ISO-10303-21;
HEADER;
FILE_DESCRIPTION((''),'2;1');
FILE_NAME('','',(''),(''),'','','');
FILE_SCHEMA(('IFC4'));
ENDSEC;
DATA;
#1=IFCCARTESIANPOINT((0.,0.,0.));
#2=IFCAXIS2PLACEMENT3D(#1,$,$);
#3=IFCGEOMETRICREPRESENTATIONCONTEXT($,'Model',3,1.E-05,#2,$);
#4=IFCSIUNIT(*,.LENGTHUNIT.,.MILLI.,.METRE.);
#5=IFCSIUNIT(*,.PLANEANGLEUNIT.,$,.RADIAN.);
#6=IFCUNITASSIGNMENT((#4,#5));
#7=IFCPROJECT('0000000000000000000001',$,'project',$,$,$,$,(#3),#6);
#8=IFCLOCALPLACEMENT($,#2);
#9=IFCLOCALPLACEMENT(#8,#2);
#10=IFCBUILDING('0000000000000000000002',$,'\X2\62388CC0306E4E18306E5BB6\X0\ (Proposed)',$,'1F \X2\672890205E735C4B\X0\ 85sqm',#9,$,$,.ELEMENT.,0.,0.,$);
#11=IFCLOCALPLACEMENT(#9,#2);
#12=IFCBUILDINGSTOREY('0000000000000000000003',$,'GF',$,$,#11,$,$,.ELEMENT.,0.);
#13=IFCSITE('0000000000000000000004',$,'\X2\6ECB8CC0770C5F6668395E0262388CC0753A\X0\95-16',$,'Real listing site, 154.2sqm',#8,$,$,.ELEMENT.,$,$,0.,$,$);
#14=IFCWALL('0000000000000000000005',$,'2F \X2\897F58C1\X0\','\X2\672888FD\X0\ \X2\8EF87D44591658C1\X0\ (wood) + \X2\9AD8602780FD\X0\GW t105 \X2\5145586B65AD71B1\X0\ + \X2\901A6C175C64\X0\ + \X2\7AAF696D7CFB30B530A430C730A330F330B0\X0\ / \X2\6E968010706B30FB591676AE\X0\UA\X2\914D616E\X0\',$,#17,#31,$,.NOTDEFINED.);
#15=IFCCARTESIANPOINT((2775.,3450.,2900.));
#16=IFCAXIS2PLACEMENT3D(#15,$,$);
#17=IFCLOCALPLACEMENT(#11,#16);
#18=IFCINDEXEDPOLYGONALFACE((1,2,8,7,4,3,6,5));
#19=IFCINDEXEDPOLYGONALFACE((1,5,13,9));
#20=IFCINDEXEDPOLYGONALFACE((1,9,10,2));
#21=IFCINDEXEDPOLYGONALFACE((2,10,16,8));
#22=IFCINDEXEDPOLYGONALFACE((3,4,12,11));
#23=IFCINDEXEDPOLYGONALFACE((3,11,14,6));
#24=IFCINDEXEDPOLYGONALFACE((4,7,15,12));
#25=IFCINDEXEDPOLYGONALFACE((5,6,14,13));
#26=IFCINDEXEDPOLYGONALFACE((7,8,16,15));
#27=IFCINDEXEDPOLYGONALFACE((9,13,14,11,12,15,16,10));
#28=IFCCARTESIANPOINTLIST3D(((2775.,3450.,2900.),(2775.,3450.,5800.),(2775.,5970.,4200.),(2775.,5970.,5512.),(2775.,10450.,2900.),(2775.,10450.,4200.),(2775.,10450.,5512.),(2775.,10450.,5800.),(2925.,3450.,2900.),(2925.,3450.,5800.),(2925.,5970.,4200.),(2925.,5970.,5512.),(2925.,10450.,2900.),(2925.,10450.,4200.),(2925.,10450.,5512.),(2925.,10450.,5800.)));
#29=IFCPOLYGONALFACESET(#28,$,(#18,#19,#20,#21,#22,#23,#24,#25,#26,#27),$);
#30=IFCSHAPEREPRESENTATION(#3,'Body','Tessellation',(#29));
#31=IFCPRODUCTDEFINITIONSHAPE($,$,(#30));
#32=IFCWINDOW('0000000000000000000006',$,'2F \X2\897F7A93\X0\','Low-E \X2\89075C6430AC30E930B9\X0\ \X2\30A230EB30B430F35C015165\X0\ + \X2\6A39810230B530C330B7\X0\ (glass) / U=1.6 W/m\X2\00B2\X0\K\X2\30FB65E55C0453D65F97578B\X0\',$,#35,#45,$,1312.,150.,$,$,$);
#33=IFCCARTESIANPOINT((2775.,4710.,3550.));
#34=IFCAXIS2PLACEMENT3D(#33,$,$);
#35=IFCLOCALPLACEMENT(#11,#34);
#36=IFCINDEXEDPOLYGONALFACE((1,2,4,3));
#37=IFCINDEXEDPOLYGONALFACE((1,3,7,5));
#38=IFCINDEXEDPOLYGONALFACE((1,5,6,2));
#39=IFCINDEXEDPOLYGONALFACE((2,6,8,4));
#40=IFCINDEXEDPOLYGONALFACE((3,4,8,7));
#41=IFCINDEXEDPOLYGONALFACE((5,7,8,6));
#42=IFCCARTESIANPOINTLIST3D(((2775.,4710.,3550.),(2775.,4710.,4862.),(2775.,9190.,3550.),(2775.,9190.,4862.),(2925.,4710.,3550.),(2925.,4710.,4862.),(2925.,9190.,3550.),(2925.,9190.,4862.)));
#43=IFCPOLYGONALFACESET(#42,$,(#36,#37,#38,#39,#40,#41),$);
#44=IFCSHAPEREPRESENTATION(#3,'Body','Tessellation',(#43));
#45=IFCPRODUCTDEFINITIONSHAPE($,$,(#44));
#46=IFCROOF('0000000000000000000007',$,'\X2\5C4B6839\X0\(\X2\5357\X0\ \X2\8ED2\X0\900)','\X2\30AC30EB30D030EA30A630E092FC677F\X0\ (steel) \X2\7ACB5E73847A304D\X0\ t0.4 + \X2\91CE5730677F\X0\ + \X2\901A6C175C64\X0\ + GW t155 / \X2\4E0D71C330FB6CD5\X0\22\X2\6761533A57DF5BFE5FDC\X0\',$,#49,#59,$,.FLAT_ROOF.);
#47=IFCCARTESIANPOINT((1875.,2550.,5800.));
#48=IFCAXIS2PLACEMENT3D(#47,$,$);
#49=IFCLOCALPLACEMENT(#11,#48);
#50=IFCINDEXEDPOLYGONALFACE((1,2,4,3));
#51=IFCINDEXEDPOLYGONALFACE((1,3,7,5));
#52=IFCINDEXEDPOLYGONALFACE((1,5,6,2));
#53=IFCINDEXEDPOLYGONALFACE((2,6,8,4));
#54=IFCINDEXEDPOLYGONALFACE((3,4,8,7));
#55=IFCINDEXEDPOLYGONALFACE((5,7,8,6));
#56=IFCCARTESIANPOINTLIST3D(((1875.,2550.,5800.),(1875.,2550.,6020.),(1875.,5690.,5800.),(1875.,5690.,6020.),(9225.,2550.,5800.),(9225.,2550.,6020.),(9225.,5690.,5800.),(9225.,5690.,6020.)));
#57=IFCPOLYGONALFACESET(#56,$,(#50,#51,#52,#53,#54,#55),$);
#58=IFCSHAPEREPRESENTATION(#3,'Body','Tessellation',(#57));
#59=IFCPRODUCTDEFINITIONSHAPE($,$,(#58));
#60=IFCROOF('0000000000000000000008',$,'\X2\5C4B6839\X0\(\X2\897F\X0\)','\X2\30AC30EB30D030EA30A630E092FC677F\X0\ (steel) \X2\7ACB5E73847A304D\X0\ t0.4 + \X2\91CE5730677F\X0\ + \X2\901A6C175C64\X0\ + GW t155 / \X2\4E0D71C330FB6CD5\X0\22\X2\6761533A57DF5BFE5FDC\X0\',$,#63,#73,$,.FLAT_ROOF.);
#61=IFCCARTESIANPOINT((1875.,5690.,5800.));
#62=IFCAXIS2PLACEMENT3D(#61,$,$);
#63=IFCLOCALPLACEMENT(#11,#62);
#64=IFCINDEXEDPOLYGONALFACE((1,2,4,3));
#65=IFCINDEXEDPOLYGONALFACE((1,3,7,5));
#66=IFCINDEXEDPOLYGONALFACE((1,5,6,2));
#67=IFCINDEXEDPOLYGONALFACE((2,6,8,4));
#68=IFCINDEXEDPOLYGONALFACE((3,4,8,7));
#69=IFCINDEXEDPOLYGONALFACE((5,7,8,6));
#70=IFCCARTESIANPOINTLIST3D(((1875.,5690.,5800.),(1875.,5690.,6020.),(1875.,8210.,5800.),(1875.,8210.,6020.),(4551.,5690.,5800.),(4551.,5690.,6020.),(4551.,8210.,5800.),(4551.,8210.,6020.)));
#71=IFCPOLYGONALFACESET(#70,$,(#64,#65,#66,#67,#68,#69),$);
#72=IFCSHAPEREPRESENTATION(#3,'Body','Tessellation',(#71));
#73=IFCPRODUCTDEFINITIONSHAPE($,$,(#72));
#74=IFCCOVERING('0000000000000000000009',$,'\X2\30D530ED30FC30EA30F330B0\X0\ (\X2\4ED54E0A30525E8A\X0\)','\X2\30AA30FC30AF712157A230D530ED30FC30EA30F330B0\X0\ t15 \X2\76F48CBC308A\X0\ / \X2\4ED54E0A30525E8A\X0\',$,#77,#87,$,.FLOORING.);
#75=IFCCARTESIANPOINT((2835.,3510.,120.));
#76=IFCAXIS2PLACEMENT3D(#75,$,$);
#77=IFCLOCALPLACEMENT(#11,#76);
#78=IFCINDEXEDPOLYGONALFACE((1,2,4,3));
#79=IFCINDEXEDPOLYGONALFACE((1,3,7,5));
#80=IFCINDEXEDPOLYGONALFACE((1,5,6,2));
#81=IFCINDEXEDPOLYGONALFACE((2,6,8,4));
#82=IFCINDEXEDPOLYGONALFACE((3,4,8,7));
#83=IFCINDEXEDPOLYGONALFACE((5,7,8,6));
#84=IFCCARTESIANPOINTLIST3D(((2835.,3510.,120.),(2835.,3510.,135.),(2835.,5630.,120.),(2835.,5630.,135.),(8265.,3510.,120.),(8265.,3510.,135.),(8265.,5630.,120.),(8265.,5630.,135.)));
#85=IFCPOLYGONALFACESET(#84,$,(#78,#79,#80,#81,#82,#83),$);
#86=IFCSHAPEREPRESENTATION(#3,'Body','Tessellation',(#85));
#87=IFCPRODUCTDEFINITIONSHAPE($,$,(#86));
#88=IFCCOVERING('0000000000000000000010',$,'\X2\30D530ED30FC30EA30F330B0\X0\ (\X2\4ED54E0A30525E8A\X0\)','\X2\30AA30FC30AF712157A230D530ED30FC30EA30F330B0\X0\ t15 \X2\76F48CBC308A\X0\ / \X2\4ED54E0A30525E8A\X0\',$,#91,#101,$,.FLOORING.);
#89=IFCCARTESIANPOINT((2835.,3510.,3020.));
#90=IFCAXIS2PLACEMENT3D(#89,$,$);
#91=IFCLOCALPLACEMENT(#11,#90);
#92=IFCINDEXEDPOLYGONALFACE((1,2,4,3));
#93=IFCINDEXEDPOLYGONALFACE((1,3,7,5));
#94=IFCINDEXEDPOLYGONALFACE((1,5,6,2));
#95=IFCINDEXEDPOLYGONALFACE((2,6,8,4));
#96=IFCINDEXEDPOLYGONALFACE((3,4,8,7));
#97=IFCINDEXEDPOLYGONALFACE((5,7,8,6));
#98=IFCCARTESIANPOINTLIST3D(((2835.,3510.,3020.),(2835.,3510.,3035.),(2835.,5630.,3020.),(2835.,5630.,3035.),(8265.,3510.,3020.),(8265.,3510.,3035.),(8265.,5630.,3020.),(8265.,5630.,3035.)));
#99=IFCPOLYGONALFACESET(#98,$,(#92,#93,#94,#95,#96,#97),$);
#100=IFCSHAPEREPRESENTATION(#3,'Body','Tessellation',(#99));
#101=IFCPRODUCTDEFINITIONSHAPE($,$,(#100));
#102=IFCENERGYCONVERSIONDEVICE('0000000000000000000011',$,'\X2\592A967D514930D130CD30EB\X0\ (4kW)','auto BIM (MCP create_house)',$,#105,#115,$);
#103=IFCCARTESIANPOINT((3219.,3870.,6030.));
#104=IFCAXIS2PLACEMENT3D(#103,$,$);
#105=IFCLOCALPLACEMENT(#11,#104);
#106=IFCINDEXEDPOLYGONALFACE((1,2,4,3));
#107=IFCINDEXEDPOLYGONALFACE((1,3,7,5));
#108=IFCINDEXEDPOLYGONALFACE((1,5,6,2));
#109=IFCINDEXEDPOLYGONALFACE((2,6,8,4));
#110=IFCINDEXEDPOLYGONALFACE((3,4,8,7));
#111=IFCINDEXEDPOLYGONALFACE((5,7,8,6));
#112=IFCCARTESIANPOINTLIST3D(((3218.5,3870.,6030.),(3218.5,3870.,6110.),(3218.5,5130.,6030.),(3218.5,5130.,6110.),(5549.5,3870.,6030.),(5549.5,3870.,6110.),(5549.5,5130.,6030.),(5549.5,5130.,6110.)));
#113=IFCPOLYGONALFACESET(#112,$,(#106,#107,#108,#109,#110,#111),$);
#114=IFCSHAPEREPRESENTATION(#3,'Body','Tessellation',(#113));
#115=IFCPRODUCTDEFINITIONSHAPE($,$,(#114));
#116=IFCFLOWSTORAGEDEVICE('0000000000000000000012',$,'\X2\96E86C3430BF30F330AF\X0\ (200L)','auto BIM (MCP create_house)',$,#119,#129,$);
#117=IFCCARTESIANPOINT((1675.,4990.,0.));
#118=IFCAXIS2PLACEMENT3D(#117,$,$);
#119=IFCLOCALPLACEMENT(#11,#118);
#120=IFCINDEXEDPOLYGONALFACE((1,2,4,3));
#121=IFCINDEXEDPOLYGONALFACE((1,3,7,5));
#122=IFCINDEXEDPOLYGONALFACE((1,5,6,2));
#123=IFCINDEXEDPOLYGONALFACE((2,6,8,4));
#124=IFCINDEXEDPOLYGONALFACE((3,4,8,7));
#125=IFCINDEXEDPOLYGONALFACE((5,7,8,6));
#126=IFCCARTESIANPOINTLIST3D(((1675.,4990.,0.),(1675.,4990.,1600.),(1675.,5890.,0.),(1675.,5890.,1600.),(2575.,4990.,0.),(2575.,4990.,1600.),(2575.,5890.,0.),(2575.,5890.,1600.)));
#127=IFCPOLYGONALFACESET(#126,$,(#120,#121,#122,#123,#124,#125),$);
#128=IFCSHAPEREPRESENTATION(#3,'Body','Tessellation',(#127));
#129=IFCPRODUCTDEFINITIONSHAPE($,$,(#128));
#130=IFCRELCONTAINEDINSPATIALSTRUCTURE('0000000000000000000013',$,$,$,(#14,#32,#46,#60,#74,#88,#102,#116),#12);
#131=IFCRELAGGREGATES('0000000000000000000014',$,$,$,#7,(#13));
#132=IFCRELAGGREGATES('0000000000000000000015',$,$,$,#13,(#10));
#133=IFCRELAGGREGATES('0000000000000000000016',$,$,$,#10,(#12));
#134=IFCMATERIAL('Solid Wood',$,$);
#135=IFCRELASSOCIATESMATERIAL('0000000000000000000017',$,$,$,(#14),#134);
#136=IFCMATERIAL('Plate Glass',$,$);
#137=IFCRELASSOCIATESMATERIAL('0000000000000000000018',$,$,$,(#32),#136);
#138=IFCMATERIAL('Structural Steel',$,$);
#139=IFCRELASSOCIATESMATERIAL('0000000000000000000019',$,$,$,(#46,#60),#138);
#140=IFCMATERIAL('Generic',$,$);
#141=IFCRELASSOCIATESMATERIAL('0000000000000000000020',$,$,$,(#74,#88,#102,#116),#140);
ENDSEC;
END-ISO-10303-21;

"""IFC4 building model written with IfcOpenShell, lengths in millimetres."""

from ifc_helpers import new_model, si_unit, frame, frame_2d, origin, place, context, project, spatial, rectangle, extrude, material, element, fill, save


model = new_model("IFC4")

# Units and contexts
model_context = context("Model", 3, precision=1e-05, world=origin())
ifc_project = project(units=[si_unit("LENGTHUNIT", "METRE", prefix="MILLI"), si_unit("PLANEANGLEUNIT", "RADIAN")], contexts=[model_context])

# Site, building, storey
site_placement = place(None, origin())
site = spatial("IfcSite", under=ifc_project, at=site_placement, Name="滋賀県彦根市戸賀町95-16", ObjectType="Real listing site, 154.2sqm", CompositionType="ELEMENT", RefElevation=0.0)
building_placement = place(site_placement, origin())
building = spatial("IfcBuilding", under=site, at=building_placement, Name="戸賀の丘の家 (Proposed)", ObjectType="1F 木造平屋 85sqm", CompositionType="ELEMENT", ElevationOfRefHeight=0.0, ElevationOfTerrain=0.0)
storey_placement = place(building_placement, origin())
storey = spatial("IfcBuildingStorey", under=building, at=storey_placement, Name="GF", CompositionType="ELEMENT", Elevation=0.0)

# Shared definitions
ifc_material_1 = material(Name="Solid Wood")
ifc_material_2 = material(Name="Generic")

# Shared definitions
ifc_material_3 = material(Name="Plate Glass")

# Wall, opening, window
wall_1_placement = place(storey_placement, frame((2775.0, 3450.0, 2900.0)))
wall_1 = element("IfcWall", 1, at=wall_1_placement, inside=storey, material=ifc_material_1, Name="2F 西壁", Description="木製 軸組外壁 (wood) + 高性能GW t105 充填断熱 + 通気層 + 窯業系サイディング / 準耐火・外皮UA配慮", PredefinedType="NOTDEFINED", context=model_context, shape_type="SweptSolid", body=[
    extrude(rectangle(XDim=150.0, YDim=7000.0, at=frame_2d((75.0, 3500.0))), frame((2775.0, 3450.0, 2900.0)), (0.0, 0.0, 1.0), 2900.0),
])
opening_1_placement = place(storey_placement, frame((2775.0, 4710.0, 3550.0)))
opening_1 = element("IfcOpeningElement", 2, at=opening_1_placement, cuts=wall_1, PredefinedType="NOTDEFINED", context=model_context, shape_type="SweptSolid", body=[
    extrude(rectangle(XDim=150.0, YDim=4480.0, at=frame_2d((75.0, 2240.0))), frame((2775.0, 4710.0, 3550.0)), (0.0, 0.0, 1.0), 1312.0),
])
window_1_placement = place(storey_placement, frame((2775.0, 4710.0, 3550.0)))
window_1 = element("IfcWindow", 3, at=window_1_placement, inside=storey, material=ifc_material_3, Name="2F 西窓", Description="Low-E 複層ガラス アルゴン封入 + 樹脂サッシ (glass) / U=1.6 W/m²K・日射取得型", OverallHeight=1312.0, OverallWidth=150.0, context=model_context, shape_type="SweptSolid", body=[
    extrude(rectangle(XDim=150.0, YDim=4480.0, at=frame_2d((75.0, 2240.0))), frame((2775.0, 4710.0, 3550.0)), (0.0, 0.0, 1.0), 1312.0),
])
fill(opening_1, window_1)

# Roofs
ifc_material_4 = material(Name="Structural Steel")
roof_1_placement = place(storey_placement, frame((1875.0, 2550.0, 5800.0)))
element("IfcRoof", 4, at=roof_1_placement, inside=storey, material=ifc_material_4, Name="屋根(南 軒900)", Description="ガルバリウム鋼板 (steel) 立平葺き t0.4 + 野地板 + 通気層 + GW t155 / 不燃・法22条区域対応", PredefinedType="FLAT_ROOF", context=model_context, shape_type="SweptSolid", body=[
    extrude(rectangle(XDim=7350.0, YDim=3140.0, at=frame_2d((3675.0, 1570.0))), frame((1875.0, 2550.0, 5800.0)), (0.0, 0.0, 1.0), 220.0),
])
roof_2_placement = place(storey_placement, frame((1875.0, 5690.0, 5800.0)))
element("IfcRoof", 5, at=roof_2_placement, inside=storey, material=ifc_material_4, Name="屋根(西)", Description="ガルバリウム鋼板 (steel) 立平葺き t0.4 + 野地板 + 通気層 + GW t155 / 不燃・法22条区域対応", PredefinedType="FLAT_ROOF", context=model_context, shape_type="SweptSolid", body=[
    extrude(rectangle(XDim=2676.0, YDim=2520.0, at=frame_2d((1338.0, 1260.0))), frame((1875.0, 5690.0, 5800.0)), (0.0, 0.0, 1.0), 220.0),
])

# Coverings
covering_1_placement = place(storey_placement, frame((2835.0, 3510.0, 120.0)))
element("IfcCovering", 6, at=covering_1_placement, inside=storey, material=ifc_material_2, Name="フローリング (仕上げ床)", Description="オーク無垢フローリング t15 直貼り / 仕上げ床", PredefinedType="FLOORING", context=model_context, shape_type="SweptSolid", body=[
    extrude(rectangle(XDim=5430.0, YDim=2120.0, at=frame_2d((2715.0, 1060.0))), frame((2835.0, 3510.0, 120.0)), (0.0, 0.0, 1.0), 15.0),
])
covering_2_placement = place(storey_placement, frame((2835.0, 3510.0, 3020.0)))
element("IfcCovering", 7, at=covering_2_placement, inside=storey, material=ifc_material_2, Name="フローリング (仕上げ床)", Description="オーク無垢フローリング t15 直貼り / 仕上げ床", PredefinedType="FLOORING", context=model_context, shape_type="SweptSolid", body=[
    extrude(rectangle(XDim=5430.0, YDim=2120.0, at=frame_2d((2715.0, 1060.0))), frame((2835.0, 3510.0, 3020.0)), (0.0, 0.0, 1.0), 15.0),
])

# Energy conversion device
energy_conversion_device_placement = place(storey_placement, frame((3219.0, 3870.0, 6030.0)))
element("IfcEnergyConversionDevice", 8, at=energy_conversion_device_placement, inside=storey, material=ifc_material_2, Name="太陽光パネル (4kW)", Description="auto BIM (MCP create_house)", context=model_context, shape_type="SweptSolid", body=[
    extrude(rectangle(XDim=2331.0, YDim=1260.0, at=frame_2d((1165.0, 630.0))), frame((3219.0, 3870.0, 6030.0)), (0.0, 0.0, 1.0), 80.0),
])

# Flow storage device
flow_storage_device_placement = place(storey_placement, frame((1675.0, 4990.0, 0.0)))
element("IfcFlowStorageDevice", 9, at=flow_storage_device_placement, inside=storey, material=ifc_material_2, Name="雨水タンク (200L)", Description="auto BIM (MCP create_house)", context=model_context, shape_type="SweptSolid", body=[
    extrude(rectangle(XDim=900.0, YDim=900.0, at=frame_2d((450.0, 450.0))), frame((1675.0, 4990.0, 0.0)), (0.0, 0.0, 1.0), 1600.0),
])

save(model, "model.ifc")
